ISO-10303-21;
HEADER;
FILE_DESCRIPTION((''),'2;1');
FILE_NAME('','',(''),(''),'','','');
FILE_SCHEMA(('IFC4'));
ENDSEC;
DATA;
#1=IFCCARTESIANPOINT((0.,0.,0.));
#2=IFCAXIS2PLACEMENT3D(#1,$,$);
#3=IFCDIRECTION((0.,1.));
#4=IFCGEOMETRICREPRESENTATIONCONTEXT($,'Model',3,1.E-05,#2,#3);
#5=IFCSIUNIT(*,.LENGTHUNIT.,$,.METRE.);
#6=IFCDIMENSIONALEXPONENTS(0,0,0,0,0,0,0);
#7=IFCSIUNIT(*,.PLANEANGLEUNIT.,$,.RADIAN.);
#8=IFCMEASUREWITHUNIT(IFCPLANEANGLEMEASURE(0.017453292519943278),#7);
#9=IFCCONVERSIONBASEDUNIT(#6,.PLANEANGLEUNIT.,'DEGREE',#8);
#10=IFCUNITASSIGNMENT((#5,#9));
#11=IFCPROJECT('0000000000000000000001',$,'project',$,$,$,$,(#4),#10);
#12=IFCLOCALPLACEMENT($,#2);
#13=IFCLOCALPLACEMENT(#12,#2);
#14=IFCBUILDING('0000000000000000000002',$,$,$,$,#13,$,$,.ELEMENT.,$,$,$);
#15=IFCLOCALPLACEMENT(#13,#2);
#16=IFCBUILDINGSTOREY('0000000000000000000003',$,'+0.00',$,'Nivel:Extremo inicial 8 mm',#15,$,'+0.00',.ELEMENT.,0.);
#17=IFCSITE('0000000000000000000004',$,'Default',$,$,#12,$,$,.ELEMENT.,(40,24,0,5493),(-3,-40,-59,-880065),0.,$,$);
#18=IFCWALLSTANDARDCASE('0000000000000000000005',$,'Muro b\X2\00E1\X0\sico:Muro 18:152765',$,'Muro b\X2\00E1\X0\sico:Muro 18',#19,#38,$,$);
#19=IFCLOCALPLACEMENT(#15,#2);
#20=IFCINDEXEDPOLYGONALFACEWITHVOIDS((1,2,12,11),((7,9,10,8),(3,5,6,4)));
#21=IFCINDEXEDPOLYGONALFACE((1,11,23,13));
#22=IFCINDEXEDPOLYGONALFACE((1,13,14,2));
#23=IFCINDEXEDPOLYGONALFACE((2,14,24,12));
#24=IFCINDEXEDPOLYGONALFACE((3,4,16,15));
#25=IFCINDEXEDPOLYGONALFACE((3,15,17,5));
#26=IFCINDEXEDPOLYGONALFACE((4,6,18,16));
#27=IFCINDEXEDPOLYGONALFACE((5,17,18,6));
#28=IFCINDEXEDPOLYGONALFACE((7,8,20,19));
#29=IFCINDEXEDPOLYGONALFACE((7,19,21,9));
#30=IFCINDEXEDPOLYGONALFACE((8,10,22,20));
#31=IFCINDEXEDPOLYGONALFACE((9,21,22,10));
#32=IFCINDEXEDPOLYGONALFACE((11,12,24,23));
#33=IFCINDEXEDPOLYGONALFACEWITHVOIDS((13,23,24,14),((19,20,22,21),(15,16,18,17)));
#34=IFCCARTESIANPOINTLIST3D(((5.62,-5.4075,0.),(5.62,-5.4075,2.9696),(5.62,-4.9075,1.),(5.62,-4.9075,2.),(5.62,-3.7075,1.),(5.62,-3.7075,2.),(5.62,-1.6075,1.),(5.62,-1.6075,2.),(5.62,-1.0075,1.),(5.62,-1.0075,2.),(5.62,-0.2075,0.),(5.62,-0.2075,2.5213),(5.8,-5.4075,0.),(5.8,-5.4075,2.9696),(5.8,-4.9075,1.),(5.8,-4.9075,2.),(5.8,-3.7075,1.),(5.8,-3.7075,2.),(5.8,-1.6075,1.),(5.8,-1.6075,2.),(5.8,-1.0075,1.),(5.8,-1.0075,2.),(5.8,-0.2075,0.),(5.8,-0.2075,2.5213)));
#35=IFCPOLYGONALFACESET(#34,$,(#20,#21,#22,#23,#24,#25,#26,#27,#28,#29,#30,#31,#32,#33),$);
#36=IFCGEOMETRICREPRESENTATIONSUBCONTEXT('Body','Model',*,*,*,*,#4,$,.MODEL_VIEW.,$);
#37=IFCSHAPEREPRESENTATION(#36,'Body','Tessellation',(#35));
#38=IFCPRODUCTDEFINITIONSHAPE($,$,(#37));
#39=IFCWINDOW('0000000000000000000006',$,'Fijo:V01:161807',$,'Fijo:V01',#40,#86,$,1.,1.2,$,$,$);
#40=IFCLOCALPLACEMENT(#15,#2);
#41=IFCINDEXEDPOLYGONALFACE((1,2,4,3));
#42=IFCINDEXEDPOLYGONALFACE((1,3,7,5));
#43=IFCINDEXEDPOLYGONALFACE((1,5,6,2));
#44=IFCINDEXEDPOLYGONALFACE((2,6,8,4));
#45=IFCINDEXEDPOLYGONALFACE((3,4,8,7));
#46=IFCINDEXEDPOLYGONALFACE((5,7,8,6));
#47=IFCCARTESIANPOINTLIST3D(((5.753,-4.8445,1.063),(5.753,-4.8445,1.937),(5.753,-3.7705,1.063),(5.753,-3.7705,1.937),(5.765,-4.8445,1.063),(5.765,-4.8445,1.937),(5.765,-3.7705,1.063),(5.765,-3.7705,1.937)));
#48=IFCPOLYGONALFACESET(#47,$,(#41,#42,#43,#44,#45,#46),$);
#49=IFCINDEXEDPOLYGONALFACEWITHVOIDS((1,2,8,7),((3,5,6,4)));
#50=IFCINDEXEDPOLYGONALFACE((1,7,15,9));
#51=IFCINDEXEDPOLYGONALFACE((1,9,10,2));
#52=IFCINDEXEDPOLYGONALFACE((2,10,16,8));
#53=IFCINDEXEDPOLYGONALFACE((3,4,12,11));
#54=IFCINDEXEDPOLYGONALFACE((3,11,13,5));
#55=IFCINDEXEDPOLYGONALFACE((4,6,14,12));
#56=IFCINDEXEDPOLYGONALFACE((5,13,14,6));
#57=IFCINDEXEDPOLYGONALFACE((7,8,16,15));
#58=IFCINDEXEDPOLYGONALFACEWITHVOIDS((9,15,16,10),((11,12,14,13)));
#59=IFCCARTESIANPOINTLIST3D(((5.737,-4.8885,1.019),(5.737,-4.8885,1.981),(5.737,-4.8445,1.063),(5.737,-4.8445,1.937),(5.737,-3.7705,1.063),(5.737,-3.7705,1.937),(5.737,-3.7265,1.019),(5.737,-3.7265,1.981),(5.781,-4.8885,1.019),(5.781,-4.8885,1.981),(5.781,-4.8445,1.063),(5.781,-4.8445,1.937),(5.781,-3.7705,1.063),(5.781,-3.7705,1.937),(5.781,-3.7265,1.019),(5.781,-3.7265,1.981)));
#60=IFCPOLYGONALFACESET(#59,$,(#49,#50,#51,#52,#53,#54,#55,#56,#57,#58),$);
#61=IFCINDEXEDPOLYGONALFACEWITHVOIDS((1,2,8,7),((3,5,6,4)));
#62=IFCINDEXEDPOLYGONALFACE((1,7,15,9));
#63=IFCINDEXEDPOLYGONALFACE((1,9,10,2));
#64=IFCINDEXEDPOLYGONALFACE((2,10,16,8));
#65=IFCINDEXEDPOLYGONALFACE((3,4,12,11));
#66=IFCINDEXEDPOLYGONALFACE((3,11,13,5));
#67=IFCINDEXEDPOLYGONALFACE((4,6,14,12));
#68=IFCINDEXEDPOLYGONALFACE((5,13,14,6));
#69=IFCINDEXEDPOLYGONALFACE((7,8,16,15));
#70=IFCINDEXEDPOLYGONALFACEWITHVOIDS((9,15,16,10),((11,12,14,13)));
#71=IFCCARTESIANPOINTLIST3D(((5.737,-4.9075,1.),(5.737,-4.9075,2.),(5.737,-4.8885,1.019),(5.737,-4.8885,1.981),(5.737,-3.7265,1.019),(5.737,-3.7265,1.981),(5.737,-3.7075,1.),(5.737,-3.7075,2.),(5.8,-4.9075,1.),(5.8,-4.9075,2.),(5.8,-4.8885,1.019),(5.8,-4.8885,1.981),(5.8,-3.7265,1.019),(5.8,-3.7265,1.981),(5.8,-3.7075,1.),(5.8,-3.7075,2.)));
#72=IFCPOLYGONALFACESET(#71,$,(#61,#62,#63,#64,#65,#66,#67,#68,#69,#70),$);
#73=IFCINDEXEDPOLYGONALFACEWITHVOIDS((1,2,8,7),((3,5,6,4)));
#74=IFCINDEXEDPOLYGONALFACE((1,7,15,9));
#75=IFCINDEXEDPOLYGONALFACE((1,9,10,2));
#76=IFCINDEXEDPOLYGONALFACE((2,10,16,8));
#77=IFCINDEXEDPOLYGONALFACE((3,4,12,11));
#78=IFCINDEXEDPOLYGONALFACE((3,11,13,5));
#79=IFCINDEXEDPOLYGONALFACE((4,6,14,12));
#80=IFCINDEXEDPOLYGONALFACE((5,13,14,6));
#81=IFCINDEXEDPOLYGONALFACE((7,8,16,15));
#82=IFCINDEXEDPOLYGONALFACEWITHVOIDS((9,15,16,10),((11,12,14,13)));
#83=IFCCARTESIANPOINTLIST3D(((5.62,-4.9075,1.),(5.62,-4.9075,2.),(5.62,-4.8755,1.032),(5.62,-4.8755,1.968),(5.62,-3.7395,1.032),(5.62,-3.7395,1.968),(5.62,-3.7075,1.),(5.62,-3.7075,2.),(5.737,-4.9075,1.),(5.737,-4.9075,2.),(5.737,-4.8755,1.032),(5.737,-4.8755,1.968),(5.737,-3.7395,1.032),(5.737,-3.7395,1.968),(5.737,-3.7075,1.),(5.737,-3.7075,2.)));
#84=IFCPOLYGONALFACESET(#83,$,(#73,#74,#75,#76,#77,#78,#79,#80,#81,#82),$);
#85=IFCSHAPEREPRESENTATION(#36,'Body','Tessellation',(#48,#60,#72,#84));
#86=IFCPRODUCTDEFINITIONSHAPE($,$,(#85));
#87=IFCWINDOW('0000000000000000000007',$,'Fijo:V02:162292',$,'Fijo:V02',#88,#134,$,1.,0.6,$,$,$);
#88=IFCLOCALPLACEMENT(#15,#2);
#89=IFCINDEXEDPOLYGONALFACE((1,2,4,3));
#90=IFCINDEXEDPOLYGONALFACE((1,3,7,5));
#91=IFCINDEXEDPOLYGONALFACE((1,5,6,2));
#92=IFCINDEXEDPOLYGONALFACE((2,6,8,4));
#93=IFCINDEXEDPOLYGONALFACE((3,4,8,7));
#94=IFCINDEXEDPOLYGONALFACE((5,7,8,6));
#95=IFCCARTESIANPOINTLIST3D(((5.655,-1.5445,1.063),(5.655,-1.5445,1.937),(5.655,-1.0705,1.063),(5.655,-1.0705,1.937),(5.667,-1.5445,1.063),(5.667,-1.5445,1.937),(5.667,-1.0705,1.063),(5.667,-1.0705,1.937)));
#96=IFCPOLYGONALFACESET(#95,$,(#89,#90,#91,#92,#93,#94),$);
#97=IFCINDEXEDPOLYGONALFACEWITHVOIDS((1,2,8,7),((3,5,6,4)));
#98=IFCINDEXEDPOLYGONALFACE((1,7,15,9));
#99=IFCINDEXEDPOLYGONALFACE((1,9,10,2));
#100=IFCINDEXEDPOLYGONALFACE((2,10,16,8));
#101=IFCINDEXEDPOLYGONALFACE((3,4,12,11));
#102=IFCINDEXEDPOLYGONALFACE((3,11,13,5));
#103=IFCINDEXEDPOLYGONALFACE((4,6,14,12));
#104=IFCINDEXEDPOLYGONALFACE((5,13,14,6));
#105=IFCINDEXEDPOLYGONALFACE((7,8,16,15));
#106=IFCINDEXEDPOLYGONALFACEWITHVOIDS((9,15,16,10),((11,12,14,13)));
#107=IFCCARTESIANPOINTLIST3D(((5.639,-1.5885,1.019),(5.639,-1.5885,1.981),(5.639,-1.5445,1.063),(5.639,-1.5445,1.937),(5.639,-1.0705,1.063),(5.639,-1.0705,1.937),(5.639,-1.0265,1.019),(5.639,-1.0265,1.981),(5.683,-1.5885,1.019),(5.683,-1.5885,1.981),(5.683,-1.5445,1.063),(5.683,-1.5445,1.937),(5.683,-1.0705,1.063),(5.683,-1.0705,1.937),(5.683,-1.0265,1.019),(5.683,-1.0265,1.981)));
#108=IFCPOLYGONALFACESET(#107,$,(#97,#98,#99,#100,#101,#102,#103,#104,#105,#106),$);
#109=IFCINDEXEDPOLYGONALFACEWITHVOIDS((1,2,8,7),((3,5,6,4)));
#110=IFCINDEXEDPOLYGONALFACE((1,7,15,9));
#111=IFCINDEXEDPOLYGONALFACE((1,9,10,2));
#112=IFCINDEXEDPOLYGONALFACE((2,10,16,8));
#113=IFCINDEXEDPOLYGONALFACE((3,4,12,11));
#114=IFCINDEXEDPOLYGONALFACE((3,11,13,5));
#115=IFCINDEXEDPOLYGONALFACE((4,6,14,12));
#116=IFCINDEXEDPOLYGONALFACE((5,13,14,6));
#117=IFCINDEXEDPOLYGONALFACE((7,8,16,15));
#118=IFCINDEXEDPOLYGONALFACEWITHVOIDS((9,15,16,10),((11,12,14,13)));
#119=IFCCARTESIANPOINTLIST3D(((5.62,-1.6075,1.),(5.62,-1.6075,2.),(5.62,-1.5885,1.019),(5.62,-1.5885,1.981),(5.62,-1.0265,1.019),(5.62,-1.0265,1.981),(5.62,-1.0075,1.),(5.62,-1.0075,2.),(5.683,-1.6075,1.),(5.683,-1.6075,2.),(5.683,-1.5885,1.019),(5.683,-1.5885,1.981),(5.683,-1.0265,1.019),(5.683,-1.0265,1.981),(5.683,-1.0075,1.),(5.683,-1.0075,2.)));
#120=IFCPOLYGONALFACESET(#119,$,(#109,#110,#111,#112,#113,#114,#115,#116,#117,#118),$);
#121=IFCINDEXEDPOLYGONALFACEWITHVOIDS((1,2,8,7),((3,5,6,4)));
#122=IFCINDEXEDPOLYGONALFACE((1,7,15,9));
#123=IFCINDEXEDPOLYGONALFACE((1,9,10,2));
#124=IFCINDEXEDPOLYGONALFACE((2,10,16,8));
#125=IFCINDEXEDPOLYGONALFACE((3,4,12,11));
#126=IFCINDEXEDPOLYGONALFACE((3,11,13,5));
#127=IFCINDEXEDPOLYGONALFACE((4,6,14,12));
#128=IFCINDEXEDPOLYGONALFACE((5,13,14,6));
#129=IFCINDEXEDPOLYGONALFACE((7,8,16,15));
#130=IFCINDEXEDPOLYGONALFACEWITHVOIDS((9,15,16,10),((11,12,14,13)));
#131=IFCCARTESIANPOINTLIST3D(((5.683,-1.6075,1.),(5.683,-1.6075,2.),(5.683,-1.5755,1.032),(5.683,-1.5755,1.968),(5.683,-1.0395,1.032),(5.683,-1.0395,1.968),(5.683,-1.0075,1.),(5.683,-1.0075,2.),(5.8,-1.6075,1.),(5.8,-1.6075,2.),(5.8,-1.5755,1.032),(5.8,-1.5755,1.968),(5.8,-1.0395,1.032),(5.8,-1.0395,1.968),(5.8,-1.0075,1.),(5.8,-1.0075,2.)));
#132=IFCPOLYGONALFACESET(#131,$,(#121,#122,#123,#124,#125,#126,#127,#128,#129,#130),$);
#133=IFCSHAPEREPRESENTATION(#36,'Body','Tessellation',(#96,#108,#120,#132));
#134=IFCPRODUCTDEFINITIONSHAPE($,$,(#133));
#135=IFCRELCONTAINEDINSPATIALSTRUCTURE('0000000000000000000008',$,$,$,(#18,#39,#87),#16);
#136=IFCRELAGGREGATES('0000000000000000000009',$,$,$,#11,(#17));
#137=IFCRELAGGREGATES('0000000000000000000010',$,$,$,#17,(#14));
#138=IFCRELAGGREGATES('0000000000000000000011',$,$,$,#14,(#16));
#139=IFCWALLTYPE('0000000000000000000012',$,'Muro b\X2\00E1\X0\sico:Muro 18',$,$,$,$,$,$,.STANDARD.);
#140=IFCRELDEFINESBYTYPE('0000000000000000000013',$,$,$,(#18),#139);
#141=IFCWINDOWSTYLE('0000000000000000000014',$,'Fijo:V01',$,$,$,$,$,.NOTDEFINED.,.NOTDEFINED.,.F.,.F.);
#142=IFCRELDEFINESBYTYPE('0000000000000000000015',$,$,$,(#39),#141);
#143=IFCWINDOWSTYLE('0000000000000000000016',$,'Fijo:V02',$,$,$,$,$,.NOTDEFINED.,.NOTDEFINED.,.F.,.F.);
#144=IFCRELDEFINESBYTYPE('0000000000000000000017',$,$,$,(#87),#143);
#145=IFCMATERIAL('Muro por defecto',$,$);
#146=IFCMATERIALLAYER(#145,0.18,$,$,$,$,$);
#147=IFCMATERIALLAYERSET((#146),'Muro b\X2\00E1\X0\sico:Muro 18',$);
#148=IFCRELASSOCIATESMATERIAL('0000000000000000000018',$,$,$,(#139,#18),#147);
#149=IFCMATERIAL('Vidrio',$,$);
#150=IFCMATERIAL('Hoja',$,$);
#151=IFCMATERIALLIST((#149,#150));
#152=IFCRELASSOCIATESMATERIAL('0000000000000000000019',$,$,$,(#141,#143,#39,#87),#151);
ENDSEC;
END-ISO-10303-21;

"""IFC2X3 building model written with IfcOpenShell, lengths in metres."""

from ifc_helpers import new_model, entity, si_unit, converted_unit, direction, frame, frame_2d, origin, place, context, subcontext, project, spatial, polyline, rectangle, outline, extrude, clip, bounded_halfspace, source, transform, mapped, material, material_list, layer, layer_set, layer_usage, type_object, type_shapes, element, fill, save


model = new_model("IFC2X3")

# Units and contexts
model_context = context("Model", 3, precision=1e-05, world=origin(), true_north=direction((0.0, 1.0)))
body_context = subcontext(model_context, "Body", "Model", "MODEL_VIEW")
ifc_project = project(units=[si_unit("LENGTHUNIT", "METRE"), converted_unit("PLANEANGLEUNIT", "DEGREE", entity("IfcPlaneAngleMeasure", 0.017453292519943278), si_unit("PLANEANGLEUNIT", "RADIAN"), dimensions=[0, 0, 0, 0, 0, 0, 0])], contexts=[model_context])

# Site, building, storey
site_placement = place(None, origin())
site = spatial("IfcSite", under=ifc_project, at=site_placement, Name="Default", CompositionType="ELEMENT", RefLatitude=(40, 24, 0, 5493), RefLongitude=(-3, -40, -59, -880065), RefElevation=0.0)
building_placement = place(site_placement, origin())
building = spatial("IfcBuilding", under=site, at=building_placement, CompositionType="ELEMENT")
storey_placement = place(building_placement, origin())
storey = spatial("IfcBuildingStorey", under=building, at=storey_placement, Name="+0.00", ObjectType="Nivel:Extremo inicial 8 mm", LongName="+0.00", CompositionType="ELEMENT", Elevation=0.0)

# Wall, openings, windows
ifc_material_1 = material(Name="Muro por defecto")
ifc_layer = layer(ifc_material_1, 0.18)
ifc_layer_set = layer_set([ifc_layer], Name="Muro básico:Muro 18")
wall_type = type_object("IfcWallType", Name="Muro básico:Muro 18", PredefinedType="STANDARD", material=ifc_layer_set)
ifc_material_2 = material(Name="Vidrio")
ifc_material_3 = material(Name="Hoja")
ifc_material_list_1 = material_list([ifc_material_2, ifc_material_3])
window_style_1 = type_object("IfcWindowStyle", Name="Fijo:V01", ConstructionType="NOTDEFINED", OperationType="NOTDEFINED", ParameterTakesPrecedence=False, Sizeable=False, material=ifc_material_list_1)
shared_shape_1 = source(origin(), body_context, "Body", "SweptSolid", [
    extrude(rectangle(XDim=0.012, YDim=1.074, at=frame_2d((0.0, 0.0), x_axis=(1.0, 0.0))), frame((0.6, 0.139, 0.063), z_axis=(0.0, 0.0, 1.0), x_axis=(0.0, -1.0, 0.0)), (0.0, 0.0, 1.0), 0.874),
    extrude(outline(polyline([(-0.581, -0.481), (0.581, -0.481), (0.581, 0.481), (-0.581, 0.481), (-0.581, -0.481)]), holes=[polyline([(-0.537, -0.437), (-0.537, 0.437), (0.537, 0.437), (0.537, -0.437), (-0.537, -0.437)])]), frame((0.6, 0.117, 0.5), z_axis=(0.0, 1.0, 0.0), x_axis=(1.0, 0.0, 0.0)), (0.0, 0.0, 1.0), 0.044),
    extrude(outline(polyline([(-0.6, -0.5), (0.6, -0.5), (0.6, 0.5), (-0.6, 0.5), (-0.6, -0.5)]), holes=[polyline([(-0.581, -0.481), (-0.581, 0.481), (0.581, 0.481), (0.581, -0.481), (-0.581, -0.481)])]), frame((0.6, 0.117, 0.5), z_axis=(0.0, 1.0, 0.0), x_axis=(1.0, 0.0, 0.0)), (0.0, 0.0, 1.0), 0.063),
    extrude(outline(polyline([(-0.6, -0.5), (0.6, -0.5), (0.6, 0.5), (-0.6, 0.5), (-0.6, -0.5)]), holes=[polyline([(-0.568, -0.468), (-0.568, 0.468), (0.568, 0.468), (0.568, -0.468), (-0.568, -0.468)])]), frame((0.6, 0.0, 0.5), z_axis=(0.0, 1.0, 0.0), x_axis=(1.0, 0.0, 0.0)), (0.0, 0.0, 1.0), 0.117),
])
type_shapes(window_style_1, [shared_shape_1])
window_style_2 = type_object("IfcWindowStyle", Name="Fijo:V02", ConstructionType="NOTDEFINED", OperationType="NOTDEFINED", ParameterTakesPrecedence=False, Sizeable=False, material=ifc_material_list_1)
shared_shape_2 = source(origin(), body_context, "Body", "SweptSolid", [
    extrude(rectangle(XDim=0.012, YDim=0.474, at=frame_2d((0.0, 0.0), x_axis=(1.0, 0.0))), frame((0.3, 0.139, 0.063), z_axis=(0.0, 0.0, 1.0), x_axis=(0.0, -1.0, 0.0)), (0.0, 0.0, 1.0), 0.874),
    extrude(outline(polyline([(-0.281, -0.481), (0.281, -0.481), (0.281, 0.481), (-0.281, 0.481), (-0.281, -0.481)]), holes=[polyline([(-0.237, -0.437), (-0.237, 0.437), (0.237, 0.437), (0.237, -0.437), (-0.237, -0.437)])]), frame((0.3, 0.117, 0.5), z_axis=(0.0, 1.0, 0.0), x_axis=(1.0, 0.0, 0.0)), (0.0, 0.0, 1.0), 0.044),
    extrude(outline(polyline([(-0.3, -0.5), (0.3, -0.5), (0.3, 0.5), (-0.3, 0.5), (-0.3, -0.5)]), holes=[polyline([(-0.281, -0.481), (-0.281, 0.481), (0.281, 0.481), (0.281, -0.481), (-0.281, -0.481)])]), frame((0.3, 0.117, 0.5), z_axis=(0.0, 1.0, 0.0), x_axis=(1.0, 0.0, 0.0)), (0.0, 0.0, 1.0), 0.063),
    extrude(outline(polyline([(-0.3, -0.5), (0.3, -0.5), (0.3, 0.5), (-0.3, 0.5), (-0.3, -0.5)]), holes=[polyline([(-0.268, -0.468), (-0.268, 0.468), (0.268, 0.468), (0.268, -0.468), (-0.268, -0.468)])]), frame((0.3, 0.0, 0.5), z_axis=(0.0, 1.0, 0.0), x_axis=(1.0, 0.0, 0.0)), (0.0, 0.0, 1.0), 0.117),
])
type_shapes(window_style_2, [shared_shape_2])
ifc_layer_usage_1 = layer_usage(ifc_layer_set, "AXIS2", "POSITIVE", -0.09)
wall_1_placement = place(storey_placement, frame((5.71, -5.4075, 0.0), z_axis=(0.0, 0.0, 1.0), x_axis=(0.0, 1.0, 0.0)))
wall_1 = element("IfcWallStandardCase", 1, at=wall_1_placement, inside=storey, type_object=wall_type, material=ifc_layer_usage_1, Name="Muro básico:Muro 18:152765", ObjectType="Muro básico:Muro 18", context=body_context, shape_type="Clipping", body=[
    clip(extrude(rectangle(XDim=5.2, YDim=0.18, at=frame_2d((2.6, 0.0), x_axis=(-1.0, 0.0))), origin(), (0.0, 0.0, 1.0), 2.9696), bounded_halfspace(frame((0.0, -0.09, 2.9696), z_axis=(0.085882, 0.0, 0.996305), x_axis=(0.0, 1.0, 0.0)), False, frame((0.0, -0.09, 2.9696)), polyline([(0.0, 0.0), (5.2, 0.0), (5.2, 0.18), (0.0, 0.18), (0.0, 0.0)]))),
])
opening_1_placement = place(wall_1_placement, frame((1.7, 0.09, 1.0)))
opening_1 = element("IfcOpeningElement", 2, at=opening_1_placement, cuts=wall_1, ObjectType="Opening", context=body_context, shape_type="SweptSolid", body=[
    extrude(rectangle(XDim=1.0, YDim=1.2, at=frame_2d((0.5, 0.6), x_axis=(1.0, 0.0))), frame((0.0, 0.0, 0.0), z_axis=(0.0, -1.0, 0.0), x_axis=(0.0, 0.0, 1.0)), (0.0, 0.0, 1.0), 0.18),
])
opening_2_placement = place(wall_1_placement, frame((3.8, -0.09, 1.0)))
opening_2 = element("IfcOpeningElement", 3, at=opening_2_placement, cuts=wall_1, ObjectType="Opening", context=body_context, shape_type="SweptSolid", body=[
    extrude(rectangle(XDim=1.0, YDim=0.6, at=frame_2d((0.5, 0.3), x_axis=(1.0, 0.0))), frame((0.0, 0.0, 0.0), z_axis=(0.0, 1.0, 0.0), x_axis=(0.0, 0.0, 1.0)), (0.0, 0.0, 1.0), 0.18),
])
window_1_placement = place(opening_1_placement, frame((0.0, 0.0, 0.0), z_axis=(0.0, 0.0, 1.0), x_axis=(-1.0, 0.0, 0.0)))
window_1 = element("IfcWindow", 4, at=window_1_placement, inside=storey, type_object=window_style_1, material=ifc_material_list_1, Name="Fijo:V01:161807", ObjectType="Fijo:V01", OverallHeight=1.0, OverallWidth=1.2, context=body_context, shape_type="MappedRepresentation", body=[
    mapped(shared_shape_1, transform((0.0, 0.0, 0.0), scale=1.0)),
])
fill(opening_1, window_1)
window_2_placement = place(opening_2_placement, origin())
window_2 = element("IfcWindow", 5, at=window_2_placement, inside=storey, type_object=window_style_2, material=ifc_material_list_1, Name="Fijo:V02:162292", ObjectType="Fijo:V02", OverallHeight=1.0, OverallWidth=0.6, context=body_context, shape_type="MappedRepresentation", body=[
    mapped(shared_shape_2, transform((0.0, 0.0, 0.0), scale=1.0)),
])
fill(opening_2, window_2)

save(model, "model.ifc")
